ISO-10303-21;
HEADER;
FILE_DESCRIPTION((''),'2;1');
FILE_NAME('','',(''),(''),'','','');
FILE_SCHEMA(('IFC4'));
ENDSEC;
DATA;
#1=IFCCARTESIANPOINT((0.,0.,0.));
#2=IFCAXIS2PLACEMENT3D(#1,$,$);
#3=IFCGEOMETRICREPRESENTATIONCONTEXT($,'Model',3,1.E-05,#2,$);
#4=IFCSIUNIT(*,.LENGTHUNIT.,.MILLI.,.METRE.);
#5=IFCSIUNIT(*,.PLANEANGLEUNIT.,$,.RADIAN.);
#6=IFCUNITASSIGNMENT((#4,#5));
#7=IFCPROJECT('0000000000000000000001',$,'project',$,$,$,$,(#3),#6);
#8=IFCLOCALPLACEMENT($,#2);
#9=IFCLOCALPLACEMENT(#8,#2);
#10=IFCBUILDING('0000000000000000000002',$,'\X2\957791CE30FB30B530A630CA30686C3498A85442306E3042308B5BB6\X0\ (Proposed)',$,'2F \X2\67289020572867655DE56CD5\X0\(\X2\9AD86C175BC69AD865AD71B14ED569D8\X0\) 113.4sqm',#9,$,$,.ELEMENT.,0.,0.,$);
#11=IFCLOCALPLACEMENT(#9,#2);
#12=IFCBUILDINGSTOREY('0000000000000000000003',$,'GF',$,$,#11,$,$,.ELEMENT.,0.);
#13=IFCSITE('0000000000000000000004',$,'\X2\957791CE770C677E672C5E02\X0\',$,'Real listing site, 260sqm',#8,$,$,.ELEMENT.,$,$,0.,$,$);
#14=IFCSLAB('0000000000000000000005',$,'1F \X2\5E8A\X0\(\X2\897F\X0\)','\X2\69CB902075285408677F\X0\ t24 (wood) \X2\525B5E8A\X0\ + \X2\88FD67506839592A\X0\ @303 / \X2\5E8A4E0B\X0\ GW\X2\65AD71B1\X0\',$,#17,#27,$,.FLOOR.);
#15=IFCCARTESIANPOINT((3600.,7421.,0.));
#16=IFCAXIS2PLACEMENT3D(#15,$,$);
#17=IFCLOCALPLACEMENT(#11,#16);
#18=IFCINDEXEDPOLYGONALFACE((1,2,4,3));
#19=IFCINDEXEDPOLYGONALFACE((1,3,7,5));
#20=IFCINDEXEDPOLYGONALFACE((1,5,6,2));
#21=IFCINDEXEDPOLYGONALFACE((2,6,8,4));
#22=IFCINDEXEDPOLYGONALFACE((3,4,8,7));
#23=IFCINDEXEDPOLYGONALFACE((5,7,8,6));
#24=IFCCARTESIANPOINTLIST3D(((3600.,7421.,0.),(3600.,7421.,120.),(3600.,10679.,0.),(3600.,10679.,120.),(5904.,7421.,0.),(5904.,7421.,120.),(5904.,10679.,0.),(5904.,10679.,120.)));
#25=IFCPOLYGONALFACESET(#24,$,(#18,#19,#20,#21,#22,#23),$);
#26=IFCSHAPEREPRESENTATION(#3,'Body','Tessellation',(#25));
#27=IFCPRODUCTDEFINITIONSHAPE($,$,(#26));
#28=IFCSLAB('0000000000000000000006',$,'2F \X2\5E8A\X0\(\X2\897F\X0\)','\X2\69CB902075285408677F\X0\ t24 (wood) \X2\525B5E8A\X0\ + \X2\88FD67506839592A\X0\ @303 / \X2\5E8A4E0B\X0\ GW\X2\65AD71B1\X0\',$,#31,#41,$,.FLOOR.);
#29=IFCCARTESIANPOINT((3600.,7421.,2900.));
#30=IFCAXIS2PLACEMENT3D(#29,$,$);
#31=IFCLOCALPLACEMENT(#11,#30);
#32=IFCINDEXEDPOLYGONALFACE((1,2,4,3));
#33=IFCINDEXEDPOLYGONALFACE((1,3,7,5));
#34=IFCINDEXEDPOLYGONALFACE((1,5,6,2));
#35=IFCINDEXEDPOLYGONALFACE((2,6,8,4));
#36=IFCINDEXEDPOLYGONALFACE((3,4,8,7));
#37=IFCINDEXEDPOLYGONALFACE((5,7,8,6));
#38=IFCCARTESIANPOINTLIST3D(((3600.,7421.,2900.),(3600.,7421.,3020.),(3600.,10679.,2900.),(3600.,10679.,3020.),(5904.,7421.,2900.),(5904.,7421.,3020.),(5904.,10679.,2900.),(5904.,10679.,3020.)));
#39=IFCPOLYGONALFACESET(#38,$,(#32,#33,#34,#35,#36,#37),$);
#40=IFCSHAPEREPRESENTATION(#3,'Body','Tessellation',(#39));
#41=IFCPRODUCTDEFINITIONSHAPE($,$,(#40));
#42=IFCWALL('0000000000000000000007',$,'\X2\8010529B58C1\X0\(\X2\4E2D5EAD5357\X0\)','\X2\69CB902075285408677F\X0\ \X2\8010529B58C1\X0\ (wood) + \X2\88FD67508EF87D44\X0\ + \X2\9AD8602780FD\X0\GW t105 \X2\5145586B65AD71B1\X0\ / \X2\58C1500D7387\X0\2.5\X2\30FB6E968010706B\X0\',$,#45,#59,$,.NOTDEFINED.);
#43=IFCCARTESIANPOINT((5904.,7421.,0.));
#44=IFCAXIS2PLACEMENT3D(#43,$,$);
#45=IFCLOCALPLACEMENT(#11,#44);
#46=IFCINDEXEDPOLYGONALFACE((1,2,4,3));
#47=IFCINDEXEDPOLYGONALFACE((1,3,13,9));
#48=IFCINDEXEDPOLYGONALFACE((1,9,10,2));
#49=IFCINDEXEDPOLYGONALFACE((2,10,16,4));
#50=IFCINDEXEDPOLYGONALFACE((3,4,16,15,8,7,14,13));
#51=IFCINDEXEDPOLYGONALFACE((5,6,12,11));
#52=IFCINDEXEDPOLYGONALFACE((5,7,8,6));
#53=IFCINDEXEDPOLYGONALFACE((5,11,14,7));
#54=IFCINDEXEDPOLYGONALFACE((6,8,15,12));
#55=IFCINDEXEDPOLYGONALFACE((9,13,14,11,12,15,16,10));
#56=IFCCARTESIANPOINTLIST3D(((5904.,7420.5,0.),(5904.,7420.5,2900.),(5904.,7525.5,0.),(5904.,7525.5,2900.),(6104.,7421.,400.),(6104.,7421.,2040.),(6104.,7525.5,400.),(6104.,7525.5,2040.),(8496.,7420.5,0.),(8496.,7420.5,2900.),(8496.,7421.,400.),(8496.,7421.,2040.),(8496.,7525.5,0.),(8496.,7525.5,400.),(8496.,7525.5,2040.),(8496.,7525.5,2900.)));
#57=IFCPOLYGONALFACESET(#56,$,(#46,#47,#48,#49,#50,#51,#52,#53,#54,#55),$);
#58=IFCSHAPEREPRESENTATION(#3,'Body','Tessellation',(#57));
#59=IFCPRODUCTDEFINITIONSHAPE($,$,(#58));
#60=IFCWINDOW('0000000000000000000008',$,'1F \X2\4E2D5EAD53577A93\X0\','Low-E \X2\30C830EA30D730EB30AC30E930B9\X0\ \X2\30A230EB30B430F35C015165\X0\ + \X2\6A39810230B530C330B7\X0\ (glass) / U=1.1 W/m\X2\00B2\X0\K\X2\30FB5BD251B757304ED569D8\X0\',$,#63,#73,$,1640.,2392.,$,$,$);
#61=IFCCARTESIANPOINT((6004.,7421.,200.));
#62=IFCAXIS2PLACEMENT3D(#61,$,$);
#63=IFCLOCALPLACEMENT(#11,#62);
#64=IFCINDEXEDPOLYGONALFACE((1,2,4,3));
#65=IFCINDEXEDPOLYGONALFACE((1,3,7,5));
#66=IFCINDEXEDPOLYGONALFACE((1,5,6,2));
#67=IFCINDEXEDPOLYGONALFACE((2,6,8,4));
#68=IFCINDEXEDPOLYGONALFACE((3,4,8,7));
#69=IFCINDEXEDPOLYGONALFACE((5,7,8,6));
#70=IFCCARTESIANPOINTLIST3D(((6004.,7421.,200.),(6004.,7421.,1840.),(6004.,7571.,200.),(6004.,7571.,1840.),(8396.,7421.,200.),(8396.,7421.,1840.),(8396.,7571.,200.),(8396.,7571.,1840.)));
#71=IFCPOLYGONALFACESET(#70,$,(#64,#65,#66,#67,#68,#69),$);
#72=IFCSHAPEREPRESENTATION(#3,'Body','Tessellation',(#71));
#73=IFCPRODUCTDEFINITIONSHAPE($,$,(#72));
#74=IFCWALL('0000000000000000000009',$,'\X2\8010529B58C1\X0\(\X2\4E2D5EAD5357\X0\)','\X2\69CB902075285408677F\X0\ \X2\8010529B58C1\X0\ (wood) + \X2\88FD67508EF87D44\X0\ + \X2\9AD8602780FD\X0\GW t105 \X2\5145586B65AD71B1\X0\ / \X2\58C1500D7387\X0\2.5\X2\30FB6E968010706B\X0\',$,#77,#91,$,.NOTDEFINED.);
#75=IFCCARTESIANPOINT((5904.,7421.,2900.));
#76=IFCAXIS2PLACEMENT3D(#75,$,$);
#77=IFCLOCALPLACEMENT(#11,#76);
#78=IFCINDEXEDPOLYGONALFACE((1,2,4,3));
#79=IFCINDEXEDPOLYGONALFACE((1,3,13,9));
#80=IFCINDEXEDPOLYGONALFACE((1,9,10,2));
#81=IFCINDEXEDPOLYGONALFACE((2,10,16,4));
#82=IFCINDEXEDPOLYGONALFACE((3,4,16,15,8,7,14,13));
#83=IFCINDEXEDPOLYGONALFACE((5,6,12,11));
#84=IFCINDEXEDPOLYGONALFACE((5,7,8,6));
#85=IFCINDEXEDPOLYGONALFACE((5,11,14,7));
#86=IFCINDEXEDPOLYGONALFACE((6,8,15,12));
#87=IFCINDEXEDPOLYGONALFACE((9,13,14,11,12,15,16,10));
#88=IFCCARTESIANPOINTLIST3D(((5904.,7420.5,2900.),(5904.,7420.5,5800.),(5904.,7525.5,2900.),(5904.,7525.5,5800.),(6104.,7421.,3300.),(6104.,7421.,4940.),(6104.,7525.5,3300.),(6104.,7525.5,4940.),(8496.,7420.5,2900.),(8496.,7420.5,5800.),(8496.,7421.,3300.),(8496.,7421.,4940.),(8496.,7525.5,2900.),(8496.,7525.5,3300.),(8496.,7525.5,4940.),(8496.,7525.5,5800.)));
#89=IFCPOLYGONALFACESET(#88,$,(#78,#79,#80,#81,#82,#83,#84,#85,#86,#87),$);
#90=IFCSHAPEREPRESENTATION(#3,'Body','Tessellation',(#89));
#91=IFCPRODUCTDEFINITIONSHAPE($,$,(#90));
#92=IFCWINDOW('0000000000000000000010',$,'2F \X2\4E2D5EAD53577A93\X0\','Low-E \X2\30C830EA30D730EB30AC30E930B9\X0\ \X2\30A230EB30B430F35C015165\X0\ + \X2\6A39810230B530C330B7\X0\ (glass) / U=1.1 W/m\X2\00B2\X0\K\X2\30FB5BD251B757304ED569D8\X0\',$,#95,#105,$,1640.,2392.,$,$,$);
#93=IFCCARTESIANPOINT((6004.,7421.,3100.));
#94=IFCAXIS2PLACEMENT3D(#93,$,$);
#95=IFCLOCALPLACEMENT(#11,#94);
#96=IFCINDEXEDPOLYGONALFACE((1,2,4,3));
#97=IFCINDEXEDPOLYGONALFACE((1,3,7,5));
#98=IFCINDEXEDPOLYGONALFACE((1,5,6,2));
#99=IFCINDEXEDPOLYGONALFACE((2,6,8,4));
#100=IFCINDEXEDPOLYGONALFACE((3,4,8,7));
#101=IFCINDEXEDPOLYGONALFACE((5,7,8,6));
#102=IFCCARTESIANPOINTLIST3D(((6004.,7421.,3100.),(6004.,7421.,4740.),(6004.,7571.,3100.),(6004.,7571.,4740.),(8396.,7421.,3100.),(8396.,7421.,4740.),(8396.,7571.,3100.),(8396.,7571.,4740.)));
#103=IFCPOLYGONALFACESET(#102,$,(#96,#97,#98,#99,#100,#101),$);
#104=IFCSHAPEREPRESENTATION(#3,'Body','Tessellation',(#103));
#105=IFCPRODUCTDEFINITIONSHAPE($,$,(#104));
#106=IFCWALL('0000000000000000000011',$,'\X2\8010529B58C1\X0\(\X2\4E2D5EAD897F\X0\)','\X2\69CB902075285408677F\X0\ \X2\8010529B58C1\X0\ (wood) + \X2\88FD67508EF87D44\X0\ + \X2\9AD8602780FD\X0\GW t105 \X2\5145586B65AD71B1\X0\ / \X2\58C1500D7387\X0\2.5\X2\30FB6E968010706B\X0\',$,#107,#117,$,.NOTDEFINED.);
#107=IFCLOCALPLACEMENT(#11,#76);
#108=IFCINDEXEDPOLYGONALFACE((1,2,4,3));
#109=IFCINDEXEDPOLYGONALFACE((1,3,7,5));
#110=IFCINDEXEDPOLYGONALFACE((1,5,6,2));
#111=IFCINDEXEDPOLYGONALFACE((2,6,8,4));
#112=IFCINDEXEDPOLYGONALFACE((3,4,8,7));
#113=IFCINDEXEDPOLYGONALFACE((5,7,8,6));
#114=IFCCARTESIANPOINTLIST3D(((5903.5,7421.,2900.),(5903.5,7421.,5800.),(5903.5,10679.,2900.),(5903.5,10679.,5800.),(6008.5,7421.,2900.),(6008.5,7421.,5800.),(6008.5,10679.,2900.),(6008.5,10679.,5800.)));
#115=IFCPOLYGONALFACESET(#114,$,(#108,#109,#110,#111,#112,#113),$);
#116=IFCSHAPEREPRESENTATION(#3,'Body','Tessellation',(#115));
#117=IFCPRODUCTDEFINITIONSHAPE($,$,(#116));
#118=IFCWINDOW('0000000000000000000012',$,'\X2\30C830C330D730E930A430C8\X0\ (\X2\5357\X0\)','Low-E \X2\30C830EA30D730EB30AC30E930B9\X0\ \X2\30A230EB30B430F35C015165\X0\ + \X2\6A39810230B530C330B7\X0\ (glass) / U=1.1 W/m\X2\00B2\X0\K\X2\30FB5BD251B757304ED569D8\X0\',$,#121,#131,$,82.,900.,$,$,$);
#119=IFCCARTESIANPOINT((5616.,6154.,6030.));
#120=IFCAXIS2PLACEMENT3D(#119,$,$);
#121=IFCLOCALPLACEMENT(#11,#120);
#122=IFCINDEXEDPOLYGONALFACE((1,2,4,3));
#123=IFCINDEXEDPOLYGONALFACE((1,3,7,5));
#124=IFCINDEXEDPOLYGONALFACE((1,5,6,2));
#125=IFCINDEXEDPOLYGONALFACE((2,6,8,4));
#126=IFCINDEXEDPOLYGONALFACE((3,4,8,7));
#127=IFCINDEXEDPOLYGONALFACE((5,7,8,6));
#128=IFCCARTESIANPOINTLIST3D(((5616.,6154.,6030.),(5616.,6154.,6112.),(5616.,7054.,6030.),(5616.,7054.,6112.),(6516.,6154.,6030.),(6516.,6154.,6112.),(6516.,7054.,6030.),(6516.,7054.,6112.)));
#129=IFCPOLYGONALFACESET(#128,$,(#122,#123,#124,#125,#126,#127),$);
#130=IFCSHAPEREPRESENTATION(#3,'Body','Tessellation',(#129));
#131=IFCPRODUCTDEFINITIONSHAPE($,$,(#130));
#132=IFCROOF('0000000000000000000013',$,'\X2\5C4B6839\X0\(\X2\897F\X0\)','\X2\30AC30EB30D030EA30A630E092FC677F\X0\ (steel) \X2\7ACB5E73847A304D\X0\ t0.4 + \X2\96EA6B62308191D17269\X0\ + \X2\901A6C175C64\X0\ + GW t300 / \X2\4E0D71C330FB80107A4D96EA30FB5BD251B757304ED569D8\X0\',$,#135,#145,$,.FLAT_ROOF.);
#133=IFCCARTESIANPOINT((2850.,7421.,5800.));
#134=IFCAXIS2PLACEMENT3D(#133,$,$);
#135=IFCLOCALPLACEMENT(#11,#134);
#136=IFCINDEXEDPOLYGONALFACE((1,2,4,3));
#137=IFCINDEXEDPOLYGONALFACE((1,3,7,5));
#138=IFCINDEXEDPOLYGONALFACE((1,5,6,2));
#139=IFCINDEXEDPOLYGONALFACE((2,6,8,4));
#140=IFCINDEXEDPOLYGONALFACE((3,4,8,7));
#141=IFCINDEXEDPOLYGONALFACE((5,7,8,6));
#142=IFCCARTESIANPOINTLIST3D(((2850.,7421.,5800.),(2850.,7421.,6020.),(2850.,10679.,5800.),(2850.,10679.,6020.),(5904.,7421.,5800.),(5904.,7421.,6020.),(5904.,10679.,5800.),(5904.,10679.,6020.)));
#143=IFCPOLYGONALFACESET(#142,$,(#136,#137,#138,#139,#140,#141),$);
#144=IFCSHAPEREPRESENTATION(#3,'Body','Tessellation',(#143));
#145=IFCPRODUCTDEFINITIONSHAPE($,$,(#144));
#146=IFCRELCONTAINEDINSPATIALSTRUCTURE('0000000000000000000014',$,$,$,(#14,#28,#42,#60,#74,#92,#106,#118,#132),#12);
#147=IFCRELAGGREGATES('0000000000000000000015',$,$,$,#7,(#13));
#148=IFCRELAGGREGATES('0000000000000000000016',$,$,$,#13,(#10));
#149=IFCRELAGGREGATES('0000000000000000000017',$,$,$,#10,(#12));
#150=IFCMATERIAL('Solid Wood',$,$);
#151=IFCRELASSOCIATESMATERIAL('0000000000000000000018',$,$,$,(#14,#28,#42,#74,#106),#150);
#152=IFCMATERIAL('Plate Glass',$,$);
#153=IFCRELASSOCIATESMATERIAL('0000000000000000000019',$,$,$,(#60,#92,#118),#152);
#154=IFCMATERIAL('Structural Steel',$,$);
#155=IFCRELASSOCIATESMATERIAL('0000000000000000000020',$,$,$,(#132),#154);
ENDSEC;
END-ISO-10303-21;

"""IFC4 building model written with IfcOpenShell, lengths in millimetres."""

from ifc_helpers import new_model, si_unit, frame, frame_2d, origin, place, context, project, spatial, rectangle, extrude, material, element, fill, save


model = new_model("IFC4")

# Units and contexts
model_context = context("Model", 3, precision=1e-05, world=origin())
ifc_project = project(units=[si_unit("LENGTHUNIT", "METRE", prefix="MILLI"), si_unit("PLANEANGLEUNIT", "RADIAN")], contexts=[model_context])

# Site, building, storey
site_placement = place(None, origin())
site = spatial("IfcSite", under=ifc_project, at=site_placement, Name="長野県松本市", ObjectType="Real listing site, 260sqm", CompositionType="ELEMENT", RefElevation=0.0)
building_placement = place(site_placement, origin())
building = spatial("IfcBuilding", under=site, at=building_placement, Name="長野・サウナと水風呂のある家 (Proposed)", ObjectType="2F 木造在来工法(高気密高断熱仕様) 113.4sqm", CompositionType="ELEMENT", ElevationOfRefHeight=0.0, ElevationOfTerrain=0.0)
storey_placement = place(building_placement, origin())
storey = spatial("IfcBuildingStorey", under=building, at=storey_placement, Name="GF", CompositionType="ELEMENT", Elevation=0.0)

# Shared definitions
ifc_material_1 = material(Name="Solid Wood")

# Slabs
slab_1_placement = place(storey_placement, frame((3600.0, 7421.0, 0.0)))
element("IfcSlab", 1, at=slab_1_placement, inside=storey, material=ifc_material_1, Name="1F 床(西)", Description="構造用合板 t24 (wood) 剛床 + 製材根太 @303 / 床下 GW断熱", PredefinedType="FLOOR", context=model_context, shape_type="SweptSolid", body=[
    extrude(rectangle(XDim=2304.0, YDim=3258.0, at=frame_2d((1152.0, 1629.0))), frame((3600.0, 7421.0, 0.0)), (0.0, 0.0, 1.0), 120.0),
])
slab_2_placement = place(storey_placement, frame((3600.0, 7421.0, 2900.0)))
element("IfcSlab", 2, at=slab_2_placement, inside=storey, material=ifc_material_1, Name="2F 床(西)", Description="構造用合板 t24 (wood) 剛床 + 製材根太 @303 / 床下 GW断熱", PredefinedType="FLOOR", context=model_context, shape_type="SweptSolid", body=[
    extrude(rectangle(XDim=2304.0, YDim=3258.0, at=frame_2d((1152.0, 1629.0))), frame((3600.0, 7421.0, 2900.0)), (0.0, 0.0, 1.0), 120.0),
])

# Wall, opening, window
wall_1_placement = place(storey_placement, frame((5904.0, 7421.0, 0.0)))
wall_1 = element("IfcWall", 3, at=wall_1_placement, inside=storey, material=ifc_material_1, Name="耐力壁(中庭南)", Description="構造用合板 耐力壁 (wood) + 製材軸組 + 高性能GW t105 充填断熱 / 壁倍率2.5・準耐火", PredefinedType="NOTDEFINED", context=model_context, shape_type="SweptSolid", body=[
    extrude(rectangle(XDim=2592.0, YDim=105.0, at=frame_2d((1296.0, 52.0))), frame((5904.0, 7421.0, 0.0)), (0.0, 0.0, 1.0), 2900.0),
])
opening_1_placement = place(storey_placement, frame((6004.0, 7421.0, 200.0)))
opening_1 = element("IfcOpeningElement", 4, at=opening_1_placement, cuts=wall_1, PredefinedType="NOTDEFINED", context=model_context, shape_type="SweptSolid", body=[
    extrude(rectangle(XDim=2392.0, YDim=150.0, at=frame_2d((1196.0, 75.0))), frame((6004.0, 7421.0, 200.0)), (0.0, 0.0, 1.0), 1640.0),
])
ifc_material_2 = material(Name="Plate Glass")
window_1_placement = place(storey_placement, frame((6004.0, 7421.0, 200.0)))
window_1 = element("IfcWindow", 5, at=window_1_placement, inside=storey, material=ifc_material_2, Name="1F 中庭南窓", Description="Low-E トリプルガラス アルゴン封入 + 樹脂サッシ (glass) / U=1.1 W/m²K・寒冷地仕様", OverallHeight=1640.0, OverallWidth=2392.0, context=model_context, shape_type="SweptSolid", body=[
    extrude(rectangle(XDim=2392.0, YDim=150.0, at=frame_2d((1196.0, 75.0))), frame((6004.0, 7421.0, 200.0)), (0.0, 0.0, 1.0), 1640.0),
])
fill(opening_1, window_1)

# Wall, opening, window
wall_2_placement = place(storey_placement, frame((5904.0, 7421.0, 2900.0)))
wall_2 = element("IfcWall", 6, at=wall_2_placement, inside=storey, material=ifc_material_1, Name="耐力壁(中庭南)", Description="構造用合板 耐力壁 (wood) + 製材軸組 + 高性能GW t105 充填断熱 / 壁倍率2.5・準耐火", PredefinedType="NOTDEFINED", context=model_context, shape_type="SweptSolid", body=[
    extrude(rectangle(XDim=2592.0, YDim=105.0, at=frame_2d((1296.0, 52.0))), frame((5904.0, 7421.0, 2900.0)), (0.0, 0.0, 1.0), 2900.0),
])
opening_2_placement = place(storey_placement, frame((6004.0, 7421.0, 3100.0)))
opening_2 = element("IfcOpeningElement", 7, at=opening_2_placement, cuts=wall_2, PredefinedType="NOTDEFINED", context=model_context, shape_type="SweptSolid", body=[
    extrude(rectangle(XDim=2392.0, YDim=150.0, at=frame_2d((1196.0, 75.0))), frame((6004.0, 7421.0, 3100.0)), (0.0, 0.0, 1.0), 1640.0),
])
window_2_placement = place(storey_placement, frame((6004.0, 7421.0, 3100.0)))
window_2 = element("IfcWindow", 8, at=window_2_placement, inside=storey, material=ifc_material_2, Name="2F 中庭南窓", Description="Low-E トリプルガラス アルゴン封入 + 樹脂サッシ (glass) / U=1.1 W/m²K・寒冷地仕様", OverallHeight=1640.0, OverallWidth=2392.0, context=model_context, shape_type="SweptSolid", body=[
    extrude(rectangle(XDim=2392.0, YDim=150.0, at=frame_2d((1196.0, 75.0))), frame((6004.0, 7421.0, 3100.0)), (0.0, 0.0, 1.0), 1640.0),
])
fill(opening_2, window_2)

# Wall
wall_3_placement = place(storey_placement, frame((5904.0, 7421.0, 2900.0)))
element("IfcWall", 9, at=wall_3_placement, inside=storey, material=ifc_material_1, Name="耐力壁(中庭西)", Description="構造用合板 耐力壁 (wood) + 製材軸組 + 高性能GW t105 充填断熱 / 壁倍率2.5・準耐火", PredefinedType="NOTDEFINED", context=model_context, shape_type="SweptSolid", body=[
    extrude(rectangle(XDim=105.0, YDim=3258.0, at=frame_2d((52.0, 1629.0))), frame((5904.0, 7421.0, 2900.0)), (0.0, 0.0, 1.0), 2900.0),
])

# Window
window_3_placement = place(storey_placement, frame((5616.0, 6154.0, 6030.0)))
element("IfcWindow", 10, at=window_3_placement, inside=storey, material=ifc_material_2, Name="トップライト (南)", Description="Low-E トリプルガラス アルゴン封入 + 樹脂サッシ (glass) / U=1.1 W/m²K・寒冷地仕様", OverallHeight=82.0, OverallWidth=900.0, context=model_context, shape_type="SweptSolid", body=[
    extrude(rectangle(XDim=900.0, YDim=900.0, at=frame_2d((450.0, 450.0))), frame((5616.0, 6154.0, 6030.0)), (0.0, 0.0, 1.0), 82.0),
])

# Roof
ifc_material_3 = material(Name="Structural Steel")
for number, where, name in (
    (11, (2850.0, 7421.0, 5800.0), "屋根(西)"),
):
    element("IfcRoof", number, at=place(storey_placement, frame(where)), inside=storey, material=ifc_material_3, Name=name, Description="ガルバリウム鋼板 (steel) 立平葺き t0.4 + 雪止め金物 + 通気層 + GW t300 / 不燃・耐積雪・寒冷地仕様", PredefinedType="FLAT_ROOF", context=model_context, shape_type="SweptSolid", body=[
        extrude(rectangle(XDim=3054.0, YDim=3258.0, at=frame_2d((1527.0, 1629.0))), frame((2850.0, 7421.0, 5800.0)), (0.0, 0.0, 1.0), 220.0),
    ])

save(model, "model.ifc")
